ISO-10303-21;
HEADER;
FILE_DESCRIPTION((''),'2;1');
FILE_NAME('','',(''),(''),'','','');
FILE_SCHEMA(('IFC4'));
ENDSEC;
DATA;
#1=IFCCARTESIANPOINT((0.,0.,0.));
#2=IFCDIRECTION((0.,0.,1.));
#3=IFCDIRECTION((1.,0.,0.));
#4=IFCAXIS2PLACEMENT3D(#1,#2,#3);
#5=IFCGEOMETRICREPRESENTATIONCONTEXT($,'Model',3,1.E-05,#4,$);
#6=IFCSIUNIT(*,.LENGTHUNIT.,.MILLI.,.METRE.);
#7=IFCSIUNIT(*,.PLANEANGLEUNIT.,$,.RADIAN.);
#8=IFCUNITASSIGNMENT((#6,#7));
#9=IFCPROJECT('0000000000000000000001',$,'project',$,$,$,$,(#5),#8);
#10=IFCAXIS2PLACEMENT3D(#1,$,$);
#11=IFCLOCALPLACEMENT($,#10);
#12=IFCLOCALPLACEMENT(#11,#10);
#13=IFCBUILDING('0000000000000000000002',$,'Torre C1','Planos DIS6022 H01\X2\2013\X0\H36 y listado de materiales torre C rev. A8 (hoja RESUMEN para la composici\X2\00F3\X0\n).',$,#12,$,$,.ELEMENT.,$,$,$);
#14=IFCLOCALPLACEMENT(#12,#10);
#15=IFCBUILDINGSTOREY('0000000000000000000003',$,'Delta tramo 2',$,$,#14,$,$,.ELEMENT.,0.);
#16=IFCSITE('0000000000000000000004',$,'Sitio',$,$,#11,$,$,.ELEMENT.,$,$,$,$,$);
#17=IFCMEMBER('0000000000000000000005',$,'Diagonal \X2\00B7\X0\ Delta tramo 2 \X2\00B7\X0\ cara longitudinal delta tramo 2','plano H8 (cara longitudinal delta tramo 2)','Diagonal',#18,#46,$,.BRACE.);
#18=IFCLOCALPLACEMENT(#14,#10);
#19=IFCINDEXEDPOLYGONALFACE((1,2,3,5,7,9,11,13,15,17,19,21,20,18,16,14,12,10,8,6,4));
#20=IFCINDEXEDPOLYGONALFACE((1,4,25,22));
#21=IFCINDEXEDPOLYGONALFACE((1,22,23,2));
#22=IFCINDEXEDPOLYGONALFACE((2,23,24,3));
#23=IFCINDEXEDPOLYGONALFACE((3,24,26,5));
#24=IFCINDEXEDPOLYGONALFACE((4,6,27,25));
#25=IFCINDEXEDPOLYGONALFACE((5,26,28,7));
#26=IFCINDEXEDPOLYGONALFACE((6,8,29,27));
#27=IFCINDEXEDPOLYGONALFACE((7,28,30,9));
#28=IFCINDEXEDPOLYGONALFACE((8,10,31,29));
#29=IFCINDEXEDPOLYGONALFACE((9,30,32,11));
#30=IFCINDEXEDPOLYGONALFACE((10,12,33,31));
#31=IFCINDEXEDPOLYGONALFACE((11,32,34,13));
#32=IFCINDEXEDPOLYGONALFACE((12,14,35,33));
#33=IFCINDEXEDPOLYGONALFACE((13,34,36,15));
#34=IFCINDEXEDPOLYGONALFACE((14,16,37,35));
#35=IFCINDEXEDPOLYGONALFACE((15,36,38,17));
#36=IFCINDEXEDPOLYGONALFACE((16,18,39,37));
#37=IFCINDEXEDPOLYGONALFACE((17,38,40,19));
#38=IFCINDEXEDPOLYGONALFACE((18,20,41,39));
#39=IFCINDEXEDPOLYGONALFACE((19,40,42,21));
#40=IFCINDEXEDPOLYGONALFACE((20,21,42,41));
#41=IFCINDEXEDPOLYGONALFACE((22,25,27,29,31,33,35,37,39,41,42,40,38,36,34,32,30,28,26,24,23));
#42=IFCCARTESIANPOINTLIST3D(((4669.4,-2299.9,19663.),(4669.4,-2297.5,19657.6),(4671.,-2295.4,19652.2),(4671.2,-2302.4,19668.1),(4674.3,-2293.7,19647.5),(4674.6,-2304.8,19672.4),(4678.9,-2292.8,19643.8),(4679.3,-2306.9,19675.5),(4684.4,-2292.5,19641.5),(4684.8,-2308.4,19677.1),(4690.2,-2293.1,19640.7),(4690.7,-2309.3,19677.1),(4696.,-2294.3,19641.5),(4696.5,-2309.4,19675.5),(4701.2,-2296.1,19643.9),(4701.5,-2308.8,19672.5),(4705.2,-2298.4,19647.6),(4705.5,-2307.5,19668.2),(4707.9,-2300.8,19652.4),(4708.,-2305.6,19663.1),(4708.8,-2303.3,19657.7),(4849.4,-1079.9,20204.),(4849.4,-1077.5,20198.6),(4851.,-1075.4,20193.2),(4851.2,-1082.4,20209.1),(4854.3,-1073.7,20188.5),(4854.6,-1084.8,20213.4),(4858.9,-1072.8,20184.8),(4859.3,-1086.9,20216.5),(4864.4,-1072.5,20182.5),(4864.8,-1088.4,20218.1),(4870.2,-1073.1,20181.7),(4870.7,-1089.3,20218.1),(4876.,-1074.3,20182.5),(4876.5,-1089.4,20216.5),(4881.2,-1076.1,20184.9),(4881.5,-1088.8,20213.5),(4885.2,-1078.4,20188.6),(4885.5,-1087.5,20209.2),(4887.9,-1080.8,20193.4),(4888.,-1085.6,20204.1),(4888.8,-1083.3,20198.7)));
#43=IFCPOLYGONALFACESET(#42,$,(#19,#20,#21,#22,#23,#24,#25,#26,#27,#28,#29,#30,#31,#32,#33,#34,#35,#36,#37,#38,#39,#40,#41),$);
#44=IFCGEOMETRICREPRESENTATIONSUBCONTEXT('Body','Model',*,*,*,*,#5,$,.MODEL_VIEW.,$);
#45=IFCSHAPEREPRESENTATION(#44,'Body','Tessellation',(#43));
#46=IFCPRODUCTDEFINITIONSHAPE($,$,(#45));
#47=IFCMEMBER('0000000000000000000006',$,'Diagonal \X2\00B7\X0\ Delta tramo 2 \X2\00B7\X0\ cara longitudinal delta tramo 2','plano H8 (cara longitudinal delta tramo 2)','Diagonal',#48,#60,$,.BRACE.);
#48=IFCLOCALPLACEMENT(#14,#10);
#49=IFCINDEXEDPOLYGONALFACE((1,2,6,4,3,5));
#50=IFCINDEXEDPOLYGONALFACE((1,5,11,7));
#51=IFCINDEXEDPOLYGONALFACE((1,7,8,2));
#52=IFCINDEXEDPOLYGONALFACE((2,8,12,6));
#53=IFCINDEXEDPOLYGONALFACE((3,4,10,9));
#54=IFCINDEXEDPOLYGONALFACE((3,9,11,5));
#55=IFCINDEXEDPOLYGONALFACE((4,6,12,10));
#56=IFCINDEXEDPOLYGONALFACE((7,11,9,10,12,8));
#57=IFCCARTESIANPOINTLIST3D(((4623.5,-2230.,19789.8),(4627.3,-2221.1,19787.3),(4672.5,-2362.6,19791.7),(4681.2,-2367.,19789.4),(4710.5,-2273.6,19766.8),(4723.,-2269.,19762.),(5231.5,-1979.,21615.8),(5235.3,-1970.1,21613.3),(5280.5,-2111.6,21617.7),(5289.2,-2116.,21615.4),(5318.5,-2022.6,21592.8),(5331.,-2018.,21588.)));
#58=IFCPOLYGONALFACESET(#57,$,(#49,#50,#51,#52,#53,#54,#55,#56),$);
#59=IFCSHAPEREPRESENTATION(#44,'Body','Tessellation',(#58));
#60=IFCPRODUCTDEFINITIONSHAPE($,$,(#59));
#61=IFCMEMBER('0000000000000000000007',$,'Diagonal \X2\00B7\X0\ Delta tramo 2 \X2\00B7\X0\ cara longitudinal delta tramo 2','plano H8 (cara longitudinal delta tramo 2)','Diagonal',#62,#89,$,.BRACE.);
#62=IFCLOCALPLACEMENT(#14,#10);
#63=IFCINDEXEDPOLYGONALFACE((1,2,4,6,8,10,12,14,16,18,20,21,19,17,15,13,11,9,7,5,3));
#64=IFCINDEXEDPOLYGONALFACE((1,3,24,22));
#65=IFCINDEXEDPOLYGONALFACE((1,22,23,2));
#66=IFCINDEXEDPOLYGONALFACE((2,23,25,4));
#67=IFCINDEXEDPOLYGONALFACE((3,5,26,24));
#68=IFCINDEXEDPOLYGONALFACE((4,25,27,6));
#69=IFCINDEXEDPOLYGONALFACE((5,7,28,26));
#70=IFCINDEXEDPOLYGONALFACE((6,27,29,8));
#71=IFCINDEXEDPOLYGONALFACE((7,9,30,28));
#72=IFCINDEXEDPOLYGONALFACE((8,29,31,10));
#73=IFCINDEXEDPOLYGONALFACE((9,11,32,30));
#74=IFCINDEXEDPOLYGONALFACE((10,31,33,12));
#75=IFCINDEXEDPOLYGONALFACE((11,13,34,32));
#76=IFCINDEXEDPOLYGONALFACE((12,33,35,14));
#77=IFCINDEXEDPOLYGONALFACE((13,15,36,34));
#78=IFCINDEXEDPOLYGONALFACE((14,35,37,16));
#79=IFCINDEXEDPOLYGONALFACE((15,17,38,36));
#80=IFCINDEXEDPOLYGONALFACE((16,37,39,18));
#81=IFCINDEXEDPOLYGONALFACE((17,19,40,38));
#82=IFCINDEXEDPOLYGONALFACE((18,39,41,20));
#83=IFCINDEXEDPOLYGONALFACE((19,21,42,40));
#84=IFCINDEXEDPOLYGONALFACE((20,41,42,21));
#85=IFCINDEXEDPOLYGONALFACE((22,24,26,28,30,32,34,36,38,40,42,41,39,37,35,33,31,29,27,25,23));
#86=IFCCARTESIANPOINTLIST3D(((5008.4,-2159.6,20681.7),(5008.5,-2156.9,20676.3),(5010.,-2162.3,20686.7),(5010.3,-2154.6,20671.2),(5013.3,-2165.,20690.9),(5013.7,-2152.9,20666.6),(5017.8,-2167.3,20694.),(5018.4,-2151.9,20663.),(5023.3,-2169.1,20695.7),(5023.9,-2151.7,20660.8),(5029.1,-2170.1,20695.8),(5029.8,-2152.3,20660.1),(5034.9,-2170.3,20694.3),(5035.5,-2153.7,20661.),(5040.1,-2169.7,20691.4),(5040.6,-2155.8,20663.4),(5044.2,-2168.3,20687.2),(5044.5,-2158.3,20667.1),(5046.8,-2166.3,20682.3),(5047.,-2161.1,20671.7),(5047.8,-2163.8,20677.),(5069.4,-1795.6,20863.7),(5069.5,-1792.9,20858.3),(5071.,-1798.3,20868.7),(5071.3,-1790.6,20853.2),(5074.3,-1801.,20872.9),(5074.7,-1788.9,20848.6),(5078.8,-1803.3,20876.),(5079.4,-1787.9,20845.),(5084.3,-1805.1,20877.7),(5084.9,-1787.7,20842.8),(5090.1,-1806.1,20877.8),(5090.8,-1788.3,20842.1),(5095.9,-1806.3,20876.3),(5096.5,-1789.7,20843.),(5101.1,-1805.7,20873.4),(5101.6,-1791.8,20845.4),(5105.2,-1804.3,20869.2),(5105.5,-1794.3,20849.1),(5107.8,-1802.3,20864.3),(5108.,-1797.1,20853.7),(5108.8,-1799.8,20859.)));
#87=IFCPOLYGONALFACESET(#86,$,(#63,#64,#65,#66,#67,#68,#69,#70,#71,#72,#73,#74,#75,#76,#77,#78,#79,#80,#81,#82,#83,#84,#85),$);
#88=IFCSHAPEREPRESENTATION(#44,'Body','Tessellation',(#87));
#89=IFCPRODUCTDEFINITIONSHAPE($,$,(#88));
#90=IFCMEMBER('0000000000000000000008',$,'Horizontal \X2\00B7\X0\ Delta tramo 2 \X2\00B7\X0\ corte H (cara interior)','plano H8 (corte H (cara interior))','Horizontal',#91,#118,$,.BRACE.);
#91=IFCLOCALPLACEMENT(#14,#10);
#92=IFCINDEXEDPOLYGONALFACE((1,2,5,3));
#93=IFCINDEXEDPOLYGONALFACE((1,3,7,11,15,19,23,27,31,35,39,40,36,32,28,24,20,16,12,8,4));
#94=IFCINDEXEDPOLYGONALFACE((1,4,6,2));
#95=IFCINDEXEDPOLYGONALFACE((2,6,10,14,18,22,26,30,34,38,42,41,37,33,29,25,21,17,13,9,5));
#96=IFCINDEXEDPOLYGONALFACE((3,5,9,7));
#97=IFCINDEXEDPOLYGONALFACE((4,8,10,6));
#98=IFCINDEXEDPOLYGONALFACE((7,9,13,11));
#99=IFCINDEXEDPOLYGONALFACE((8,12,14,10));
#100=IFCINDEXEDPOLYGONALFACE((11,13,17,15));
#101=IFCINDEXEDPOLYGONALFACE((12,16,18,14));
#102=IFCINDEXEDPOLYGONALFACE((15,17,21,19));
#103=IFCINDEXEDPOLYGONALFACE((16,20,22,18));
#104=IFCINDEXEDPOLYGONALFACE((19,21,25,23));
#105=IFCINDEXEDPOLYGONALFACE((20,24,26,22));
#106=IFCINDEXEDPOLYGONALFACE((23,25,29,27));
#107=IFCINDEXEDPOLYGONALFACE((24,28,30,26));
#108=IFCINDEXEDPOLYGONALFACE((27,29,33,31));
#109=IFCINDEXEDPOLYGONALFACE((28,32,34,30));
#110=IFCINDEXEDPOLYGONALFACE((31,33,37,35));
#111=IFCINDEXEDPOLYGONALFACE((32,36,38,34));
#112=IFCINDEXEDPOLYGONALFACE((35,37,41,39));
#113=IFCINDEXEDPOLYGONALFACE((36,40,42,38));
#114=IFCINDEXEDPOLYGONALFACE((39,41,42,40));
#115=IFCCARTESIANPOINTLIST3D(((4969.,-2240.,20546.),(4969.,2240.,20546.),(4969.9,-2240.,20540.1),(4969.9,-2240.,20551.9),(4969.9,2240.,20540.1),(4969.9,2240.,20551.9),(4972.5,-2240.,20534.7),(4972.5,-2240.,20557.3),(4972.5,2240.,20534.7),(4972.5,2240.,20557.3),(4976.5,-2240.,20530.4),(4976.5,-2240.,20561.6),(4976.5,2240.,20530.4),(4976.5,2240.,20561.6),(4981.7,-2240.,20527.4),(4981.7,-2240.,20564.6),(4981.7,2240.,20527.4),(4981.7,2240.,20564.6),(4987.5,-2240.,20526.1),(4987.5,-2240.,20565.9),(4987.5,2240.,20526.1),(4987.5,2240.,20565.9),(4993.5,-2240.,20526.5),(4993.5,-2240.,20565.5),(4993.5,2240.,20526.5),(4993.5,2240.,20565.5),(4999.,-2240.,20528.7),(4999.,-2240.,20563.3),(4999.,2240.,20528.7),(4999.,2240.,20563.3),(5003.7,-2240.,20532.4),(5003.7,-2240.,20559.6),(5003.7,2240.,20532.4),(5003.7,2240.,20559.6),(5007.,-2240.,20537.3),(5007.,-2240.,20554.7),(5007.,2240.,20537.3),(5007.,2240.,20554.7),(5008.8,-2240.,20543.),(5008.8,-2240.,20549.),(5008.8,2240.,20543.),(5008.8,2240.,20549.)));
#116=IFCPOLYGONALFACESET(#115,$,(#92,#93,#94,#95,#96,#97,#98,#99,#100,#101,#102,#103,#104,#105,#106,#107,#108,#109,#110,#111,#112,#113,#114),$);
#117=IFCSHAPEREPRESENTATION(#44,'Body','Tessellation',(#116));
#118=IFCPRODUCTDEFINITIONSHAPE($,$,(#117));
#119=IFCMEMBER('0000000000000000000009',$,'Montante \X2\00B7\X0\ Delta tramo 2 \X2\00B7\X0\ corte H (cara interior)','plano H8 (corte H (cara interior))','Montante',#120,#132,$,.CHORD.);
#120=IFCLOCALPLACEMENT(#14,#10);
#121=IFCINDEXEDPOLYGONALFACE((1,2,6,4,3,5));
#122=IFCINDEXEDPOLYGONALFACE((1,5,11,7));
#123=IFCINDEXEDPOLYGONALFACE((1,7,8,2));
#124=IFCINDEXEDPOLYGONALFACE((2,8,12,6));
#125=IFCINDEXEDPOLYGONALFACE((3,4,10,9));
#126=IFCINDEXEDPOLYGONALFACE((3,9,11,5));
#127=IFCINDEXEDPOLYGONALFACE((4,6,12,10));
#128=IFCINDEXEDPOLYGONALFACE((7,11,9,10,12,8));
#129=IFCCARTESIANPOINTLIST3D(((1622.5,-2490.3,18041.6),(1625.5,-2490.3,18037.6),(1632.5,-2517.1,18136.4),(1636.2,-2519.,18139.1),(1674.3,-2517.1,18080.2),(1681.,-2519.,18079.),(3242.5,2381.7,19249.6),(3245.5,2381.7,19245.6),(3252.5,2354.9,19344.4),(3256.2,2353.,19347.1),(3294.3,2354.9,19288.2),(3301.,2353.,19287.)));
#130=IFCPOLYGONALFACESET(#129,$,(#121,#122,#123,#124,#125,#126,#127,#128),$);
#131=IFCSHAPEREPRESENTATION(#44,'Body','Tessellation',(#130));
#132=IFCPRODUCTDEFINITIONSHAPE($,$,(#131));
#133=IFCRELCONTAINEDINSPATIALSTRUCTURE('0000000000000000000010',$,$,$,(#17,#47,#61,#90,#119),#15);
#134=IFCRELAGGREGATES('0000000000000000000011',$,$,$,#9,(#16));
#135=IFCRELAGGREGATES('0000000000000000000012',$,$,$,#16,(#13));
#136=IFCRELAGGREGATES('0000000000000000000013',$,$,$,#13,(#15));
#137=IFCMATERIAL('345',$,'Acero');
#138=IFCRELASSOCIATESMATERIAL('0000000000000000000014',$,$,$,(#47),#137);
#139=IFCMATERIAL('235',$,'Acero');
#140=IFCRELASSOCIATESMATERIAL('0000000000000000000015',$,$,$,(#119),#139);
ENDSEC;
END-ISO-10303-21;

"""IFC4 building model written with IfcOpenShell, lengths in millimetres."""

from ifc_helpers import new_model, si_unit, frame, frame_2d, origin, origin_with_axes, place, context, subcontext, project, spatial, circle, l_section, extrude, material, element, save


model = new_model("IFC4")

# Units and contexts
model_context = context("Model", 3, precision=1e-05, world=origin_with_axes())
body_context = subcontext(model_context, "Body", "Model", "MODEL_VIEW")
ifc_project = project(units=[si_unit("LENGTHUNIT", "METRE", prefix="MILLI"), si_unit("PLANEANGLEUNIT", "RADIAN")], contexts=[model_context])

# Site, building, storey
site_placement = place(None, origin())
site = spatial("IfcSite", under=ifc_project, at=site_placement, Name="Sitio", CompositionType="ELEMENT")
building_placement = place(site_placement, origin())
building = spatial("IfcBuilding", under=site, at=building_placement, Name="Torre C1", Description="Planos DIS6022 H01–H36 y listado de materiales torre C rev. A8 (hoja RESUMEN para la composición).", CompositionType="ELEMENT")
storey_placement = place(building_placement, origin())
storey = spatial("IfcBuildingStorey", under=building, at=storey_placement, Name="Delta tramo 2", CompositionType="ELEMENT", Elevation=0.0)

# Members
ifc_material_1 = material(Name="345", Category="Acero")
ifc_material_2 = material(Name="235", Category="Acero")
member_1_placement = place(storey_placement, frame((4689.0, -2301.0, 19659.0), z_axis=(0.133664, 0.905948, 0.401736), x_axis=(-0.981631, 0.176718, -0.071907)))
element("IfcMember", 1, at=member_1_placement, inside=storey, Name="Diagonal · Delta tramo 2 · cara longitudinal delta tramo 2", Description="plano H8 (cara longitudinal delta tramo 2)", ObjectType="Diagonal", PredefinedType="BRACE", context=body_context, shape_type="SweptSolid", body=[
    extrude(circle(Radius=20.0), None, (0.0, 0.0, 1.0), 1346.7),
])
member_2_placement = place(storey_placement, frame((4723.0, -2269.0, 19762.0), z_axis=(0.313263, 0.129324, 0.94082), x_axis=(-0.870378, 0.435386, 0.22996)))
element("IfcMember", 2, at=member_2_placement, inside=storey, material=ifc_material_1, Name="Diagonal · Delta tramo 2 · cara longitudinal delta tramo 2", Description="plano H8 (cara longitudinal delta tramo 2)", ObjectType="Diagonal", PredefinedType="BRACE", context=body_context, shape_type="SweptSolid", body=[
    extrude(l_section(Depth=110.0, Width=110.0, Thickness=10.0, at=frame_2d((55.0, 55.0))), None, (0.0, 0.0, 1.0), 1940.9),
])
member_3_placement = place(storey_placement, frame((5028.0, -2161.0, 20678.0), z_axis=(0.148234, 0.884546, 0.442273), x_axis=(-0.975269, 0.204886, -0.082896)))
element("IfcMember", 3, at=member_3_placement, inside=storey, Name="Diagonal · Delta tramo 2 · cara longitudinal delta tramo 2", Description="plano H8 (cara longitudinal delta tramo 2)", ObjectType="Diagonal", PredefinedType="BRACE", context=body_context, shape_type="SweptSolid", body=[
    extrude(circle(Radius=20.0), None, (0.0, 0.0, 1.0), 411.5),
])
member_4_placement = place(storey_placement, frame((4989.0, -2240.0, 20546.0), z_axis=(0.0, 1.0, 0.0), x_axis=(-1.0, 0.0, 0.0)))
element("IfcMember", 4, at=member_4_placement, inside=storey, Name="Horizontal · Delta tramo 2 · corte H (cara interior)", Description="plano H8 (corte H (cara interior))", ObjectType="Horizontal", PredefinedType="BRACE", context=body_context, shape_type="SweptSolid", body=[
    extrude(circle(Radius=20.0), None, (0.0, 0.0, 1.0), 4480.0),
])
member_5_placement = place(storey_placement, frame((1681.0, -2519.0, 18079.0), z_axis=(0.30714, 0.923694, 0.229028), x_axis=(-0.740489, 0.38313, -0.552167)))
element("IfcMember", 5, at=member_5_placement, inside=storey, material=ifc_material_2, Name="Montante · Delta tramo 2 · corte H (cara interior)", Description="plano H8 (corte H (cara interior))", ObjectType="Montante", PredefinedType="CHORD", context=body_context, shape_type="SweptSolid", body=[
    extrude(l_section(Depth=75.0, Width=75.0, Thickness=5.0, at=frame_2d((37.5, 37.5))), None, (0.0, 0.0, 1.0), 5274.5),
])

save(model, "model.ifc")
